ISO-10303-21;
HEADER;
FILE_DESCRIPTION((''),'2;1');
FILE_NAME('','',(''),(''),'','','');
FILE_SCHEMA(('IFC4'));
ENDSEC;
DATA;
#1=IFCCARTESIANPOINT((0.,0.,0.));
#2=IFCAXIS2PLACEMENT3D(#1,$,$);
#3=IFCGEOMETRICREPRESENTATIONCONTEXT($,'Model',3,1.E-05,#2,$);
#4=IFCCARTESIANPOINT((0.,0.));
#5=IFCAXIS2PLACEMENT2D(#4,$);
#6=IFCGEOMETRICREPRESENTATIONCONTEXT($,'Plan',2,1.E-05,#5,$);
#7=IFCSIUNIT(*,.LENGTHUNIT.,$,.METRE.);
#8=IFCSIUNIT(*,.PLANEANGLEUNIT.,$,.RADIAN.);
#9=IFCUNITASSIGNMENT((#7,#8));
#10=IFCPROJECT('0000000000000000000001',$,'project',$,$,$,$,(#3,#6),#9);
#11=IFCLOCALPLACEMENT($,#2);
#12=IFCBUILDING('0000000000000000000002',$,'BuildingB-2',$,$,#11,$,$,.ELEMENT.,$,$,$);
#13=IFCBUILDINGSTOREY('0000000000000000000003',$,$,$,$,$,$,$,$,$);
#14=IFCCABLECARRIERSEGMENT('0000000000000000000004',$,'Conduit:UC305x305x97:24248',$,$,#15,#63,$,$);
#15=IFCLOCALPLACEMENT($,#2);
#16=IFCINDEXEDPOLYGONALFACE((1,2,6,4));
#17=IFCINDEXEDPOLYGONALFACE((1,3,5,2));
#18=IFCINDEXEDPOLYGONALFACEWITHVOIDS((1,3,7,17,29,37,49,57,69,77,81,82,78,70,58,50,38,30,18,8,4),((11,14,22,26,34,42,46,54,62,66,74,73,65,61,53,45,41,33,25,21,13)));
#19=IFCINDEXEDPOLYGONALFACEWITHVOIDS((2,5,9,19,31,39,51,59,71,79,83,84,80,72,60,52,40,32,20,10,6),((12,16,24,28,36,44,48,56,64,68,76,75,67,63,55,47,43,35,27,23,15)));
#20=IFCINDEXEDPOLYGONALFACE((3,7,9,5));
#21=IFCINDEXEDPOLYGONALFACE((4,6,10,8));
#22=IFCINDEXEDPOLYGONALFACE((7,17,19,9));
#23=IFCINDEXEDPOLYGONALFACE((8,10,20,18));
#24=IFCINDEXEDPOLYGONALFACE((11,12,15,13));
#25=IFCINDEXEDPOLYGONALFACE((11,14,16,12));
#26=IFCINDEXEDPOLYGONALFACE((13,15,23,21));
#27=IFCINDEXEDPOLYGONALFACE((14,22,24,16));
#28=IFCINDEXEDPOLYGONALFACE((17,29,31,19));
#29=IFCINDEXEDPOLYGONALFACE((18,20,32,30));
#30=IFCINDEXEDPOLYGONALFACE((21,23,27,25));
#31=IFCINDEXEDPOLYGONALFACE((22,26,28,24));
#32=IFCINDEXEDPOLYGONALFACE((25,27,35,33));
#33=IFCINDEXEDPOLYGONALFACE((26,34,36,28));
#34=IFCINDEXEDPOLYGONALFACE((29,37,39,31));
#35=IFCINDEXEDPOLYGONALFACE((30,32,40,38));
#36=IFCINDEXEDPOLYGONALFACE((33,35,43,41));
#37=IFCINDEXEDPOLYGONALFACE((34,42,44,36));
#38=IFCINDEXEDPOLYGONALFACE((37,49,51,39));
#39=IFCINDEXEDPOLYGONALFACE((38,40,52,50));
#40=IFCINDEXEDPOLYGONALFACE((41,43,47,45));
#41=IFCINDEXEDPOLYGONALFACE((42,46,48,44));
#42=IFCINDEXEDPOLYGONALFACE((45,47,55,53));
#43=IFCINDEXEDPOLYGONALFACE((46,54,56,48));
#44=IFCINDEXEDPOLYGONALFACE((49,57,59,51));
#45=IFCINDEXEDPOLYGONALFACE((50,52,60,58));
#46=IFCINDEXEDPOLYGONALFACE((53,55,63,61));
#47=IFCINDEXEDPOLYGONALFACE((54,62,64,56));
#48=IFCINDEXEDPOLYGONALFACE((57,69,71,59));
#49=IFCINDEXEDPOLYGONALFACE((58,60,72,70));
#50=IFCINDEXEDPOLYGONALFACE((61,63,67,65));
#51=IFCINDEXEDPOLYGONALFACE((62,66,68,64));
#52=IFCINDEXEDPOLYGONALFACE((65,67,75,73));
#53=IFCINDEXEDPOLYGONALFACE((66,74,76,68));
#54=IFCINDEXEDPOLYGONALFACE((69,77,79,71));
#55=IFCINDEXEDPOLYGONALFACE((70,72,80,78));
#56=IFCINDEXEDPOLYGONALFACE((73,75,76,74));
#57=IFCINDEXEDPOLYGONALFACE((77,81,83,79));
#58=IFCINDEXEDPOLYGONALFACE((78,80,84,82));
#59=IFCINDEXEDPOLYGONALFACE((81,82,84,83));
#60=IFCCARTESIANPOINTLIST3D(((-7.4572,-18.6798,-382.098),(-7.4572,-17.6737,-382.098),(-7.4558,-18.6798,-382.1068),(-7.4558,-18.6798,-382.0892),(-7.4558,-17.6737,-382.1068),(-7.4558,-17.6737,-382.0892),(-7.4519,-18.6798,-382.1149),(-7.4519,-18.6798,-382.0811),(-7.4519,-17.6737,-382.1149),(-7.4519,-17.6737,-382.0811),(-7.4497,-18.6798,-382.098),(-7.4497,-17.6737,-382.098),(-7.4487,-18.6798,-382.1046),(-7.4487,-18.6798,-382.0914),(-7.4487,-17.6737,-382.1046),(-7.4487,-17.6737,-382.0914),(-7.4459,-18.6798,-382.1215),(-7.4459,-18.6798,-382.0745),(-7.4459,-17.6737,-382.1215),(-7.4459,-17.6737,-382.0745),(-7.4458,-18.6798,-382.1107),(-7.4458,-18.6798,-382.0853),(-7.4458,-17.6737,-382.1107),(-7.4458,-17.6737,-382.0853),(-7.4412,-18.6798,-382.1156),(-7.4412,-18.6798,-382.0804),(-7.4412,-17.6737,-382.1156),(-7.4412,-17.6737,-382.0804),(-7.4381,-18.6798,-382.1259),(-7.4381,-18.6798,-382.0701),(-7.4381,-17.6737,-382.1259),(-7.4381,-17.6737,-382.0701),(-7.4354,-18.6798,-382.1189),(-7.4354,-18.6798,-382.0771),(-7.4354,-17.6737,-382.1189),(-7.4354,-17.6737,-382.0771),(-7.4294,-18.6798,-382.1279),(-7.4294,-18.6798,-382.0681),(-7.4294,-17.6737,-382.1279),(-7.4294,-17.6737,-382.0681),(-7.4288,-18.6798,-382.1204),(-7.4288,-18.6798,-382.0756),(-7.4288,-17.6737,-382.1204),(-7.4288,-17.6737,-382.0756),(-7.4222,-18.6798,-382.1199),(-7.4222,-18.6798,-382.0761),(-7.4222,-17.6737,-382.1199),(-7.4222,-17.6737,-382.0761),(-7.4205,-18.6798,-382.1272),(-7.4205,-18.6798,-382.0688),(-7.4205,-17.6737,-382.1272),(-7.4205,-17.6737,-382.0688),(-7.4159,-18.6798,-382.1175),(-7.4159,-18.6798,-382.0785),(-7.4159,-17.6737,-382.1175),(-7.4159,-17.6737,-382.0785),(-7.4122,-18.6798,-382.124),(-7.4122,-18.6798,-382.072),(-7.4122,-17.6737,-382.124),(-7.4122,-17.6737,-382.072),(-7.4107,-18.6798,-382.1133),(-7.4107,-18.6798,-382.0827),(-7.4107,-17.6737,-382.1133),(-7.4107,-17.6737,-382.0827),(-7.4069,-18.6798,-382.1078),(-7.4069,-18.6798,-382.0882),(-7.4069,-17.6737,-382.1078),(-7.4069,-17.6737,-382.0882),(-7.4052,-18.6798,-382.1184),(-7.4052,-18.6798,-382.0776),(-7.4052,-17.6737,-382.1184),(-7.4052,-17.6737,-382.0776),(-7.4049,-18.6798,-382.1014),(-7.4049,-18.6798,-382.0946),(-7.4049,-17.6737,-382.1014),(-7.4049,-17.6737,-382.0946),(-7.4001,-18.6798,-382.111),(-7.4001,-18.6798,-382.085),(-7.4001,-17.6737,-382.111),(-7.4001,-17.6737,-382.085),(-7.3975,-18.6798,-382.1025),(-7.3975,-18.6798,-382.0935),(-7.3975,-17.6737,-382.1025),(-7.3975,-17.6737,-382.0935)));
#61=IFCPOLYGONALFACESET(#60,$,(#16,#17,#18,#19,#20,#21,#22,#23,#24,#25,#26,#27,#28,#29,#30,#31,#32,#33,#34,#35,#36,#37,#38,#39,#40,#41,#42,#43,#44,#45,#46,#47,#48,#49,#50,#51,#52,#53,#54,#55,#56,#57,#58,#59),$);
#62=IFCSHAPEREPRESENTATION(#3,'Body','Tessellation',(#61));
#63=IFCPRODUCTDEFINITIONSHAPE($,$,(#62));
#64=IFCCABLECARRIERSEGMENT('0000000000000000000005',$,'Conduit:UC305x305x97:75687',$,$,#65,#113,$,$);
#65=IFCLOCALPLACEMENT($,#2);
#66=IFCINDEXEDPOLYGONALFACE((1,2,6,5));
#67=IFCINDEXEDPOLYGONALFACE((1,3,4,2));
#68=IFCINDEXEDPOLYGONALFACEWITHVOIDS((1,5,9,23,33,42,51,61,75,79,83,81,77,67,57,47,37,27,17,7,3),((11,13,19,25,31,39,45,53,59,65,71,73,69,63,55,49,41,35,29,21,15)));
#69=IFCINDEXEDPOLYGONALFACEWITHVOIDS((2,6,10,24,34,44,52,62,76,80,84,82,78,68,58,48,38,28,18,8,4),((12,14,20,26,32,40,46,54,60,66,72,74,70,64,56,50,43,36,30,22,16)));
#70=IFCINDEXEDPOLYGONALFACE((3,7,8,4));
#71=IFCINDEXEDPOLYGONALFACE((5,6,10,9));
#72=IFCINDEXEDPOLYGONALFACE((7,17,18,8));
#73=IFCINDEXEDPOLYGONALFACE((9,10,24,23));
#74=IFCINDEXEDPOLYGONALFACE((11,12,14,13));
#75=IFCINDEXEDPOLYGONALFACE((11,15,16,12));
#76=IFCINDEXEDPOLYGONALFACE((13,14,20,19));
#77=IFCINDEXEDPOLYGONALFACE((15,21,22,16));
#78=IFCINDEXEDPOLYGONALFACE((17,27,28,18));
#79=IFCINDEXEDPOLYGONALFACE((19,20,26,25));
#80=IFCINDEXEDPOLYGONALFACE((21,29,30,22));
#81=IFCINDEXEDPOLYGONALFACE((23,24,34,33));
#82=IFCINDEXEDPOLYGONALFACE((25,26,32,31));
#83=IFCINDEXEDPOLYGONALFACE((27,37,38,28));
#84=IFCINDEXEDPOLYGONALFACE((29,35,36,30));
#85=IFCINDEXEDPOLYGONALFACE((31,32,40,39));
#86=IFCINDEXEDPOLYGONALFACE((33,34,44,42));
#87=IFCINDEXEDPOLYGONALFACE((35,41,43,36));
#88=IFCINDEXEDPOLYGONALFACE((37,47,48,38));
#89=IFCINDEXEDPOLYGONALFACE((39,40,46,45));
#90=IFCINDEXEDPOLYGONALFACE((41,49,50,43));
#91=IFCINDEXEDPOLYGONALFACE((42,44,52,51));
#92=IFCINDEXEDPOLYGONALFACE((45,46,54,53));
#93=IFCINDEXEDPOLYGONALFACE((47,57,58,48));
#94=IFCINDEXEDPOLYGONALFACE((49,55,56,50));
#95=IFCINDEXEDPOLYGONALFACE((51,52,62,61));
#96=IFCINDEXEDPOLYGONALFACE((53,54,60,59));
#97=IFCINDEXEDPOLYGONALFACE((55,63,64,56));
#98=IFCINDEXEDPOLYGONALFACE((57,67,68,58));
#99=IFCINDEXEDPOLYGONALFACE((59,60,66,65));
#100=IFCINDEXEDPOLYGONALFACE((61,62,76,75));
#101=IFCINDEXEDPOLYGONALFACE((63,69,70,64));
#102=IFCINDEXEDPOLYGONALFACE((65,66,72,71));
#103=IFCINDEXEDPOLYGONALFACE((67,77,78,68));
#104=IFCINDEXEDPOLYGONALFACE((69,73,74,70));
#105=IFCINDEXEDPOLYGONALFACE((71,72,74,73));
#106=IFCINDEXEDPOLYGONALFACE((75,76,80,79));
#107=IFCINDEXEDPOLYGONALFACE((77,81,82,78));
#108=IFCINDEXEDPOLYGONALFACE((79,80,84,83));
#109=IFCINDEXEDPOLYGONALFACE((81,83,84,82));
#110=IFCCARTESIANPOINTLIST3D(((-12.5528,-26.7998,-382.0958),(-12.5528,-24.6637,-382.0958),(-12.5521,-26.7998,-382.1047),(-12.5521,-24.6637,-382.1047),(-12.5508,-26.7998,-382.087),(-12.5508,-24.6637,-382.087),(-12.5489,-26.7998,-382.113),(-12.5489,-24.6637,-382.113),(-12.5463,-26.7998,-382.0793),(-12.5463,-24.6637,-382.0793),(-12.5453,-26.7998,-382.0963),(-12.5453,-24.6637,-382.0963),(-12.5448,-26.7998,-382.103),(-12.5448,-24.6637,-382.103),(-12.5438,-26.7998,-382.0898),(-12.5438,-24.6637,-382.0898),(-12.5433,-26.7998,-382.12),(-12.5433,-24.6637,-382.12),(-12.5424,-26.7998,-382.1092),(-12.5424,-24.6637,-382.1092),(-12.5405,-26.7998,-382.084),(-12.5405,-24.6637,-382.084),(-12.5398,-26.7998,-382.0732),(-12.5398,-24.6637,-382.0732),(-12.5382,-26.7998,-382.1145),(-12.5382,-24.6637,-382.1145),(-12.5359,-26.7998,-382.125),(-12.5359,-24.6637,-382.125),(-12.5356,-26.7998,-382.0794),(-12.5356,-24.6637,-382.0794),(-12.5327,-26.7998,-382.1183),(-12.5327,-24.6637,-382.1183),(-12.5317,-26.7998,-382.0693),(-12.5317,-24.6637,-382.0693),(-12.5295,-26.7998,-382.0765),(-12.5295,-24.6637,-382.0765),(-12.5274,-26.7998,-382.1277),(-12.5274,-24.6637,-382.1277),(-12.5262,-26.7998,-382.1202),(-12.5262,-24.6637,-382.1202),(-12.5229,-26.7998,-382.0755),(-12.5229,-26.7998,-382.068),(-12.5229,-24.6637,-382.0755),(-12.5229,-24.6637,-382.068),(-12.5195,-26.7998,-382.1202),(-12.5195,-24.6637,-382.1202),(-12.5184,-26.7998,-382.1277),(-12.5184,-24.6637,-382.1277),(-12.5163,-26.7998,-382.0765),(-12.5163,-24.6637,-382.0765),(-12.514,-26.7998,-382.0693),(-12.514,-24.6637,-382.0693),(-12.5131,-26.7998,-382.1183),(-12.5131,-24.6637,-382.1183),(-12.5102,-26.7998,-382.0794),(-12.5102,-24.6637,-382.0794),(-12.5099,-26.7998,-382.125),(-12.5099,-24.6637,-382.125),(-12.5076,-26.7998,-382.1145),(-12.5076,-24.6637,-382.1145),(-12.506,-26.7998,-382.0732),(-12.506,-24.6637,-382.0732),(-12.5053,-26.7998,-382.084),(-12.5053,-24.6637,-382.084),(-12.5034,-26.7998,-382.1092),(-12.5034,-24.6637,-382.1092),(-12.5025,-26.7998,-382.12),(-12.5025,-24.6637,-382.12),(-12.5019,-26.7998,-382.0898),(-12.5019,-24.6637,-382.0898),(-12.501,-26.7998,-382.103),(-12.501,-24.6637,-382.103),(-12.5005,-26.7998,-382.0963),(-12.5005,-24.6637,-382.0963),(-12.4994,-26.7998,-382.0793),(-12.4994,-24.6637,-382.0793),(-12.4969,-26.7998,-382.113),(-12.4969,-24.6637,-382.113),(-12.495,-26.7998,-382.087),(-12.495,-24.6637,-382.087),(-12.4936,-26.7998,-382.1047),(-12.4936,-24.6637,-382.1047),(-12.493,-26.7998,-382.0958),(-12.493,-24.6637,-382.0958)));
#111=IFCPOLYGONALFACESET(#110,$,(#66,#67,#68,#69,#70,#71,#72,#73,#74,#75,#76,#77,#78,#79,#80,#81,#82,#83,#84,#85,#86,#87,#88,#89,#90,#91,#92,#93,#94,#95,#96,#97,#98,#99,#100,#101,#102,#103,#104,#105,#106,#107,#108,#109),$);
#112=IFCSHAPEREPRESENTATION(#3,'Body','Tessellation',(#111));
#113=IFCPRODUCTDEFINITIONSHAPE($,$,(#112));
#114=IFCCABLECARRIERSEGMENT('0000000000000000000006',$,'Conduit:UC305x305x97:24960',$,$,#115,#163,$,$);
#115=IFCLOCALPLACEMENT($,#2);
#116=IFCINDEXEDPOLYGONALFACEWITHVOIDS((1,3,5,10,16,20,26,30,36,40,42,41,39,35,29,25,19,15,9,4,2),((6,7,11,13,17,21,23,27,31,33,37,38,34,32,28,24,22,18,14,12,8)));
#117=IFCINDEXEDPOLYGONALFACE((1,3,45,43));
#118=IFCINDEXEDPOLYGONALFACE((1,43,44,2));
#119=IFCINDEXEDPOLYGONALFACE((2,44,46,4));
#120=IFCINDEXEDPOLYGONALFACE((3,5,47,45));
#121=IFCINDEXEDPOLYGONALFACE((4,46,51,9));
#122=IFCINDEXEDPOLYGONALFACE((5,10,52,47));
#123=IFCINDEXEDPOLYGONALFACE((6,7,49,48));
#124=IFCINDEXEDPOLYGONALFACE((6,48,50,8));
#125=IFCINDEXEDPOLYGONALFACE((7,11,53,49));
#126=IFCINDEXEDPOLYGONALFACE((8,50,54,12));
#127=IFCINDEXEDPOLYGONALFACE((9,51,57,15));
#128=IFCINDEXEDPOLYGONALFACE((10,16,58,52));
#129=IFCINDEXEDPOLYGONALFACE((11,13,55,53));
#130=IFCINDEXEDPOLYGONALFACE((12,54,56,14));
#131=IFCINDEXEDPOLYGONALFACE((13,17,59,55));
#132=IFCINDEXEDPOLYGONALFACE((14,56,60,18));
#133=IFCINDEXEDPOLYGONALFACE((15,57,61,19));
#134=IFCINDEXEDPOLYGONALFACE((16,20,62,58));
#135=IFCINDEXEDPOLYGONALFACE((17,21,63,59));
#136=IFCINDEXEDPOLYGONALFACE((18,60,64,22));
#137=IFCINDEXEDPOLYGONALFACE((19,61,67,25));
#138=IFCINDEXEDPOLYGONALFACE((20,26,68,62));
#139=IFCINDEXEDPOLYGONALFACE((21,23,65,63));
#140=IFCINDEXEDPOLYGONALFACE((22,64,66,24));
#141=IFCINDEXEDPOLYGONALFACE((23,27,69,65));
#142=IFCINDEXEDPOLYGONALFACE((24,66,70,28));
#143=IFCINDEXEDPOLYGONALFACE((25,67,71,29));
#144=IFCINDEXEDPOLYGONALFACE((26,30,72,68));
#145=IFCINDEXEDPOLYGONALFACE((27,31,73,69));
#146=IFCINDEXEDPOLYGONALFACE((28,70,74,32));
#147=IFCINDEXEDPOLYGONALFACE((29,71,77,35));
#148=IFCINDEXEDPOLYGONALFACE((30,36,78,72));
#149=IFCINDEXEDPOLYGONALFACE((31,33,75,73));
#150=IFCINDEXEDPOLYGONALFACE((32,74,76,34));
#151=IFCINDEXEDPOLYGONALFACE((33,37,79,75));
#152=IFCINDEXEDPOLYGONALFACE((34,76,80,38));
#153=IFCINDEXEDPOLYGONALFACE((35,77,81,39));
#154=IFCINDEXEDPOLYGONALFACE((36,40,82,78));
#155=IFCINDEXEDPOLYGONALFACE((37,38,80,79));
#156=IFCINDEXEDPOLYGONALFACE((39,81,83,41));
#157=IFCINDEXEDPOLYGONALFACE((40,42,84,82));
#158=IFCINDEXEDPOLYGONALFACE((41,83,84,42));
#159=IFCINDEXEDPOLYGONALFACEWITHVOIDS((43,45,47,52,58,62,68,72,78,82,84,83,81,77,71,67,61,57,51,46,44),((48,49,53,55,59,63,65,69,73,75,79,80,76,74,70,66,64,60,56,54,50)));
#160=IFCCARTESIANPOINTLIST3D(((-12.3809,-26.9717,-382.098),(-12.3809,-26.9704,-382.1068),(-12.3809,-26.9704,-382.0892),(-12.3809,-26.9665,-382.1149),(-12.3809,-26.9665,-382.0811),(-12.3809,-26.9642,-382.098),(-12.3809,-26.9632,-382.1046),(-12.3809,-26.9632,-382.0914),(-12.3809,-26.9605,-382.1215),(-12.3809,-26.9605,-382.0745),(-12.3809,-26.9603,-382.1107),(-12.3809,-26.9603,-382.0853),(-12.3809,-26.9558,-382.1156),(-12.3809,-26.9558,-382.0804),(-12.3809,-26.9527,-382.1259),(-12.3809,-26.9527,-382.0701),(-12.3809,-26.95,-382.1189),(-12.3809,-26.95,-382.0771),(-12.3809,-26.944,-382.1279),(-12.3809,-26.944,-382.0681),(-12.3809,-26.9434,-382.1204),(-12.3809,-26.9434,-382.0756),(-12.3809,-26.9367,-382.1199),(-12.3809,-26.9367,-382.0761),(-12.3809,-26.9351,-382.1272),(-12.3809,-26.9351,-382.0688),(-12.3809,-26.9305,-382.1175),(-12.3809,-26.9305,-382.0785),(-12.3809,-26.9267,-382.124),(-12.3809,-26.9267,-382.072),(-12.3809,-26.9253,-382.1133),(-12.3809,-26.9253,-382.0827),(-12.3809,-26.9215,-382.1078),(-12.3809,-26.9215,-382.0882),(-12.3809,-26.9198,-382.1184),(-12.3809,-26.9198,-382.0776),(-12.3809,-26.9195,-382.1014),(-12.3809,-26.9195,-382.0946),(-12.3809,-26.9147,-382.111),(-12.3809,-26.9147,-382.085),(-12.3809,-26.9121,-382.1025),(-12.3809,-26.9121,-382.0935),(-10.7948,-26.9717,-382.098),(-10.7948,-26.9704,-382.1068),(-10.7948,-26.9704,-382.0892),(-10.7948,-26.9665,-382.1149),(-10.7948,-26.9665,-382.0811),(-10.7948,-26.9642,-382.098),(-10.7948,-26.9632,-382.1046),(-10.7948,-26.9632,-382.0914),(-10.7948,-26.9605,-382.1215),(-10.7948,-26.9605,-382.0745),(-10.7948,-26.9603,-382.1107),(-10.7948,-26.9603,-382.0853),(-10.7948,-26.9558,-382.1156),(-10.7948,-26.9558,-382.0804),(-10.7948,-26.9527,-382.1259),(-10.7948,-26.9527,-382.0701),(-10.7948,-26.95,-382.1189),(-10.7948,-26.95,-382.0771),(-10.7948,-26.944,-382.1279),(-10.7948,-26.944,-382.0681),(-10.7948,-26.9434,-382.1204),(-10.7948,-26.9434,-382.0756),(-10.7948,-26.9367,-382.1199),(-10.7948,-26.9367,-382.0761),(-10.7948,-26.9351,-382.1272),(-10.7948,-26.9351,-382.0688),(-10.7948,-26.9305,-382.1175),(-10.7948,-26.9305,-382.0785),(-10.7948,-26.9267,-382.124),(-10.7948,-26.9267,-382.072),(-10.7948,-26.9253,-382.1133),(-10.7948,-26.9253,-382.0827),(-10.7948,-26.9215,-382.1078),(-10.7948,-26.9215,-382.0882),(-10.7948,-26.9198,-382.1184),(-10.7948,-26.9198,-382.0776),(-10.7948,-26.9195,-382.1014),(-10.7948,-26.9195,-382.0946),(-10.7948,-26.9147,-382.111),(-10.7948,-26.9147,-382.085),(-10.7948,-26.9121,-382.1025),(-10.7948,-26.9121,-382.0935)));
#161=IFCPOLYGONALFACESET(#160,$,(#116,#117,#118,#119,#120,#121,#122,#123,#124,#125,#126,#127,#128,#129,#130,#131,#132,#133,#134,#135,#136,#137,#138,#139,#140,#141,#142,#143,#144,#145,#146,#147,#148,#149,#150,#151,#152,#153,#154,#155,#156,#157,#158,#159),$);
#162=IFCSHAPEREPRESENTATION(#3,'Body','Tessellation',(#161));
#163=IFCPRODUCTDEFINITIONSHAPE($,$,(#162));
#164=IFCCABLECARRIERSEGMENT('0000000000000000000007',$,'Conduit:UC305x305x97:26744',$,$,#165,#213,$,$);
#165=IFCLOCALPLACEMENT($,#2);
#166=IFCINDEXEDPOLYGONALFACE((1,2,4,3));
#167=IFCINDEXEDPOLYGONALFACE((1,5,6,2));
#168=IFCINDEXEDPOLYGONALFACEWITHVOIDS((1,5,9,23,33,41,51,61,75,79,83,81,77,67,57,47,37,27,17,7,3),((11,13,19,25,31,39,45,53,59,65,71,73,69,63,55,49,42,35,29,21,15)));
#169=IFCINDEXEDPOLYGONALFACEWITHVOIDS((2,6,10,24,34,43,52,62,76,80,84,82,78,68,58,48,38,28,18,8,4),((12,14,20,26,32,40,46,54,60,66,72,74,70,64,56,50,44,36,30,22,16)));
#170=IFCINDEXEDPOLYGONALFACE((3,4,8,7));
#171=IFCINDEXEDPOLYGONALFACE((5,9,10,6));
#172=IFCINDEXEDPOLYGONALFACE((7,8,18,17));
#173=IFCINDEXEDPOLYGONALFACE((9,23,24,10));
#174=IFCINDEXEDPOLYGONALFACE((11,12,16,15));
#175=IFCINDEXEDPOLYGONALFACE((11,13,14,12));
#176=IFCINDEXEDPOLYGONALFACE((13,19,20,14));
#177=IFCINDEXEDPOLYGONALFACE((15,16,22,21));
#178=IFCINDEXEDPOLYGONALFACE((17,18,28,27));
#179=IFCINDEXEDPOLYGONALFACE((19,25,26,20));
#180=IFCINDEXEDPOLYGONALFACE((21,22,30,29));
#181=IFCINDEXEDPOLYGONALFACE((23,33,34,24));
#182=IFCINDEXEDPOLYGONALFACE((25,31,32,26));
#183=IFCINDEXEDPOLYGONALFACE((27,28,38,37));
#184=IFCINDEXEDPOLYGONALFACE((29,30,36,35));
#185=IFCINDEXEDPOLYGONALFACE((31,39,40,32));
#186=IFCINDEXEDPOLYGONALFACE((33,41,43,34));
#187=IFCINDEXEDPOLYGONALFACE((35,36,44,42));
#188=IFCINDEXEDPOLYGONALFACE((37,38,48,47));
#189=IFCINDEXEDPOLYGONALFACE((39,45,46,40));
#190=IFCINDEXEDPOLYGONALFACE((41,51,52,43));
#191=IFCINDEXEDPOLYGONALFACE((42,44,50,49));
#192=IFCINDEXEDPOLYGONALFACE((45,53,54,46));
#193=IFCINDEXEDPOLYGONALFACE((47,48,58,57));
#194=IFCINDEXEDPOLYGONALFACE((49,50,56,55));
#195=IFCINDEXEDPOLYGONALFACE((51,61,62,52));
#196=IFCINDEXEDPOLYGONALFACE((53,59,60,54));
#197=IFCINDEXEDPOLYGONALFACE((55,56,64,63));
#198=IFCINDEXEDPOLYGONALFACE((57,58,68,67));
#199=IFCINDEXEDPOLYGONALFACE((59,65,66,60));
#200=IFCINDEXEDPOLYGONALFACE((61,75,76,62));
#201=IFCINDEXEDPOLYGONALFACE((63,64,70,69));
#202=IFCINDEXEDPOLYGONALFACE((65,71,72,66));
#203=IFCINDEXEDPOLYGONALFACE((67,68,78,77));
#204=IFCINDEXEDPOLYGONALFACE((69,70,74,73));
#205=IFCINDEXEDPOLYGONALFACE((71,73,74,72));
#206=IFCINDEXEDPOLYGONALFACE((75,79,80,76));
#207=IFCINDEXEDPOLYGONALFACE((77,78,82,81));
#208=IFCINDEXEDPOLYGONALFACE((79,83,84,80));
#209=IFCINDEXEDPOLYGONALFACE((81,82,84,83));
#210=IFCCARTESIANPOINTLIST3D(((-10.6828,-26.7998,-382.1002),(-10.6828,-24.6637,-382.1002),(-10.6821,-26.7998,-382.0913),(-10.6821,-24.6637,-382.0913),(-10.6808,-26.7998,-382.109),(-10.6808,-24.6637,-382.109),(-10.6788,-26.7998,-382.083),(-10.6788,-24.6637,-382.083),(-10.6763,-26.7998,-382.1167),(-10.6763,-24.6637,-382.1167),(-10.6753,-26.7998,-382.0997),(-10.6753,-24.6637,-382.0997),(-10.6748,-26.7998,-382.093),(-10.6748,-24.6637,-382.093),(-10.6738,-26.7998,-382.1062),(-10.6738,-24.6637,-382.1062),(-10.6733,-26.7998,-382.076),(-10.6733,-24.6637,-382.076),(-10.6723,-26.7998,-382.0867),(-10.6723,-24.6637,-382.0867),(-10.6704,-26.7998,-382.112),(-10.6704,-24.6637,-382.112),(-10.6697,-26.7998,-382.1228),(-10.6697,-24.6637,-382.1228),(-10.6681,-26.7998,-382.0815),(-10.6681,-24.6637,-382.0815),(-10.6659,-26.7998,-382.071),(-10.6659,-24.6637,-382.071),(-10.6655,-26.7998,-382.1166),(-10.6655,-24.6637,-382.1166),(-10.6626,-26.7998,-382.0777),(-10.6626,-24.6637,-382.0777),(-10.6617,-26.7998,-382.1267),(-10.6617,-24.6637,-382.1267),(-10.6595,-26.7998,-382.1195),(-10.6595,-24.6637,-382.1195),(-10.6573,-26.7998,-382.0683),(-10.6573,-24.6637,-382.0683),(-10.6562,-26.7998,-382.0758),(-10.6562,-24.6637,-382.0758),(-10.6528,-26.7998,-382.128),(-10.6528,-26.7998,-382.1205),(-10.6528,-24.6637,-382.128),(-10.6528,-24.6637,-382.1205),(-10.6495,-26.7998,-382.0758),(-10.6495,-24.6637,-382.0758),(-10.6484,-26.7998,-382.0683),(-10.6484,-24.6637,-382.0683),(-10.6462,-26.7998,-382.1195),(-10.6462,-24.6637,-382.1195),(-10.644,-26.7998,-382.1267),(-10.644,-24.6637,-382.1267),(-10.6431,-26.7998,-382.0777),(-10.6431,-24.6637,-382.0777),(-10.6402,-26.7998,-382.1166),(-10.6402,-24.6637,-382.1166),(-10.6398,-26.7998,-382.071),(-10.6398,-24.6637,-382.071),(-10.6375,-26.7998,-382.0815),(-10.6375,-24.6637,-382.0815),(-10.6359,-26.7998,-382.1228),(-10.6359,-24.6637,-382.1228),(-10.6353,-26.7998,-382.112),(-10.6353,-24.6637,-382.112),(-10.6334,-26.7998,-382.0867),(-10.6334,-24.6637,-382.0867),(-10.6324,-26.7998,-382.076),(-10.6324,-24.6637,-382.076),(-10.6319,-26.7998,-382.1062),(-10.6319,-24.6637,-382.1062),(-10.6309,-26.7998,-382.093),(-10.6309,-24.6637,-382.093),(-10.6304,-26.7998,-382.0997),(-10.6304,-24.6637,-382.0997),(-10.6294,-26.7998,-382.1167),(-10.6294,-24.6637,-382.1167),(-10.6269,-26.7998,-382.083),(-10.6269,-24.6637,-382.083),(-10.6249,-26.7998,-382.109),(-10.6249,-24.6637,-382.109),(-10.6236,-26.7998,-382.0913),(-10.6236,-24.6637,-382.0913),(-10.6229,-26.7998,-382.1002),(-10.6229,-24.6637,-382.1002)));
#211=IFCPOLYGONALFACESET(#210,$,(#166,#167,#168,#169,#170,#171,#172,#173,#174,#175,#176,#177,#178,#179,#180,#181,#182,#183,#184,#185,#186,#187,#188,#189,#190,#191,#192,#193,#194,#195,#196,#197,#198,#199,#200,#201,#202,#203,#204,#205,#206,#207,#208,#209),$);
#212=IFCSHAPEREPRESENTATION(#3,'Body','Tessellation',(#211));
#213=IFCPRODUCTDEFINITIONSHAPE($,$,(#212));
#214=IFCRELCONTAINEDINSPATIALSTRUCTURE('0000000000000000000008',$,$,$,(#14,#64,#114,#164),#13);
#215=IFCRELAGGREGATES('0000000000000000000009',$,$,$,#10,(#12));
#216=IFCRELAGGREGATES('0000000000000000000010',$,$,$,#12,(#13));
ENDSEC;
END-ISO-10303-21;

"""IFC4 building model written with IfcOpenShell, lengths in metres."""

from ifc_helpers import new_model, entity, si_unit, origin, origin_2d, place, context, project, spatial, element, save


model = new_model("IFC4")

# Units and contexts
model_context = context("Model", 3, precision=1e-05, world=origin())
plan_context = context("Plan", 2, precision=1e-05, world=origin_2d())
ifc_project = project(units=[si_unit("LENGTHUNIT", "METRE"), si_unit("PLANEANGLEUNIT", "RADIAN")], contexts=[model_context, plan_context])

# Building, storey
building_placement = place(None, origin())
building = spatial("IfcBuilding", under=ifc_project, at=building_placement, Name="BuildingB-2", CompositionType="ELEMENT")
storey = spatial("IfcBuildingStorey", under=building)

# Cable carrier segments
element("IfcCableCarrierSegment", 1, inside=storey, Name="Conduit:UC305x305x97:24248", context=model_context, shape_type="AdvancedSweptSolid", body=[
    entity("IfcSweptDiskSolid", entity("IfcCompositeCurve", [entity("IfcCompositeCurveSegment", "CONTINUOUS", False, entity("IfcPolyline", [entity("IfcCartesianPoint", [7.4272, 18.6798, 382.098]), entity("IfcCartesianPoint", [7.4272, 17.6737, 382.098])]))], False), 0.03, 0.0225),
])
element("IfcCableCarrierSegment", 2, inside=storey, Name="Conduit:UC305x305x97:75687", context=model_context, shape_type="AdvancedSweptSolid", body=[
    entity("IfcSweptDiskSolid", entity("IfcCompositeCurve", [entity("IfcCompositeCurveSegment", "CONTINUOUS", False, entity("IfcPolyline", [entity("IfcCartesianPoint", [12.5229, 24.6637, 382.098]), entity("IfcCartesianPoint", [12.5229, 26.7998, 382.098])]))], False), 0.03, 0.0225),
])
element("IfcCableCarrierSegment", 3, inside=storey, Name="Conduit:UC305x305x97:24960", context=model_context, shape_type="AdvancedSweptSolid", body=[
    entity("IfcSweptDiskSolid", entity("IfcCompositeCurve", [entity("IfcCompositeCurveSegment", "CONTINUOUS", False, entity("IfcPolyline", [entity("IfcCartesianPoint", [12.3809, 26.9417, 382.098]), entity("IfcCartesianPoint", [10.7948, 26.9417, 382.098])]))], False), 0.03, 0.0225),
])
element("IfcCableCarrierSegment", 4, inside=storey, Name="Conduit:UC305x305x97:26744", context=model_context, shape_type="AdvancedSweptSolid", body=[
    entity("IfcSweptDiskSolid", entity("IfcCompositeCurve", [entity("IfcCompositeCurveSegment", "CONTINUOUS", False, entity("IfcPolyline", [entity("IfcCartesianPoint", [10.6528, 26.7998, 382.098]), entity("IfcCartesianPoint", [10.6528, 24.6637, 382.098])]))], False), 0.03, 0.0225),
])

save(model, "model.ifc")
